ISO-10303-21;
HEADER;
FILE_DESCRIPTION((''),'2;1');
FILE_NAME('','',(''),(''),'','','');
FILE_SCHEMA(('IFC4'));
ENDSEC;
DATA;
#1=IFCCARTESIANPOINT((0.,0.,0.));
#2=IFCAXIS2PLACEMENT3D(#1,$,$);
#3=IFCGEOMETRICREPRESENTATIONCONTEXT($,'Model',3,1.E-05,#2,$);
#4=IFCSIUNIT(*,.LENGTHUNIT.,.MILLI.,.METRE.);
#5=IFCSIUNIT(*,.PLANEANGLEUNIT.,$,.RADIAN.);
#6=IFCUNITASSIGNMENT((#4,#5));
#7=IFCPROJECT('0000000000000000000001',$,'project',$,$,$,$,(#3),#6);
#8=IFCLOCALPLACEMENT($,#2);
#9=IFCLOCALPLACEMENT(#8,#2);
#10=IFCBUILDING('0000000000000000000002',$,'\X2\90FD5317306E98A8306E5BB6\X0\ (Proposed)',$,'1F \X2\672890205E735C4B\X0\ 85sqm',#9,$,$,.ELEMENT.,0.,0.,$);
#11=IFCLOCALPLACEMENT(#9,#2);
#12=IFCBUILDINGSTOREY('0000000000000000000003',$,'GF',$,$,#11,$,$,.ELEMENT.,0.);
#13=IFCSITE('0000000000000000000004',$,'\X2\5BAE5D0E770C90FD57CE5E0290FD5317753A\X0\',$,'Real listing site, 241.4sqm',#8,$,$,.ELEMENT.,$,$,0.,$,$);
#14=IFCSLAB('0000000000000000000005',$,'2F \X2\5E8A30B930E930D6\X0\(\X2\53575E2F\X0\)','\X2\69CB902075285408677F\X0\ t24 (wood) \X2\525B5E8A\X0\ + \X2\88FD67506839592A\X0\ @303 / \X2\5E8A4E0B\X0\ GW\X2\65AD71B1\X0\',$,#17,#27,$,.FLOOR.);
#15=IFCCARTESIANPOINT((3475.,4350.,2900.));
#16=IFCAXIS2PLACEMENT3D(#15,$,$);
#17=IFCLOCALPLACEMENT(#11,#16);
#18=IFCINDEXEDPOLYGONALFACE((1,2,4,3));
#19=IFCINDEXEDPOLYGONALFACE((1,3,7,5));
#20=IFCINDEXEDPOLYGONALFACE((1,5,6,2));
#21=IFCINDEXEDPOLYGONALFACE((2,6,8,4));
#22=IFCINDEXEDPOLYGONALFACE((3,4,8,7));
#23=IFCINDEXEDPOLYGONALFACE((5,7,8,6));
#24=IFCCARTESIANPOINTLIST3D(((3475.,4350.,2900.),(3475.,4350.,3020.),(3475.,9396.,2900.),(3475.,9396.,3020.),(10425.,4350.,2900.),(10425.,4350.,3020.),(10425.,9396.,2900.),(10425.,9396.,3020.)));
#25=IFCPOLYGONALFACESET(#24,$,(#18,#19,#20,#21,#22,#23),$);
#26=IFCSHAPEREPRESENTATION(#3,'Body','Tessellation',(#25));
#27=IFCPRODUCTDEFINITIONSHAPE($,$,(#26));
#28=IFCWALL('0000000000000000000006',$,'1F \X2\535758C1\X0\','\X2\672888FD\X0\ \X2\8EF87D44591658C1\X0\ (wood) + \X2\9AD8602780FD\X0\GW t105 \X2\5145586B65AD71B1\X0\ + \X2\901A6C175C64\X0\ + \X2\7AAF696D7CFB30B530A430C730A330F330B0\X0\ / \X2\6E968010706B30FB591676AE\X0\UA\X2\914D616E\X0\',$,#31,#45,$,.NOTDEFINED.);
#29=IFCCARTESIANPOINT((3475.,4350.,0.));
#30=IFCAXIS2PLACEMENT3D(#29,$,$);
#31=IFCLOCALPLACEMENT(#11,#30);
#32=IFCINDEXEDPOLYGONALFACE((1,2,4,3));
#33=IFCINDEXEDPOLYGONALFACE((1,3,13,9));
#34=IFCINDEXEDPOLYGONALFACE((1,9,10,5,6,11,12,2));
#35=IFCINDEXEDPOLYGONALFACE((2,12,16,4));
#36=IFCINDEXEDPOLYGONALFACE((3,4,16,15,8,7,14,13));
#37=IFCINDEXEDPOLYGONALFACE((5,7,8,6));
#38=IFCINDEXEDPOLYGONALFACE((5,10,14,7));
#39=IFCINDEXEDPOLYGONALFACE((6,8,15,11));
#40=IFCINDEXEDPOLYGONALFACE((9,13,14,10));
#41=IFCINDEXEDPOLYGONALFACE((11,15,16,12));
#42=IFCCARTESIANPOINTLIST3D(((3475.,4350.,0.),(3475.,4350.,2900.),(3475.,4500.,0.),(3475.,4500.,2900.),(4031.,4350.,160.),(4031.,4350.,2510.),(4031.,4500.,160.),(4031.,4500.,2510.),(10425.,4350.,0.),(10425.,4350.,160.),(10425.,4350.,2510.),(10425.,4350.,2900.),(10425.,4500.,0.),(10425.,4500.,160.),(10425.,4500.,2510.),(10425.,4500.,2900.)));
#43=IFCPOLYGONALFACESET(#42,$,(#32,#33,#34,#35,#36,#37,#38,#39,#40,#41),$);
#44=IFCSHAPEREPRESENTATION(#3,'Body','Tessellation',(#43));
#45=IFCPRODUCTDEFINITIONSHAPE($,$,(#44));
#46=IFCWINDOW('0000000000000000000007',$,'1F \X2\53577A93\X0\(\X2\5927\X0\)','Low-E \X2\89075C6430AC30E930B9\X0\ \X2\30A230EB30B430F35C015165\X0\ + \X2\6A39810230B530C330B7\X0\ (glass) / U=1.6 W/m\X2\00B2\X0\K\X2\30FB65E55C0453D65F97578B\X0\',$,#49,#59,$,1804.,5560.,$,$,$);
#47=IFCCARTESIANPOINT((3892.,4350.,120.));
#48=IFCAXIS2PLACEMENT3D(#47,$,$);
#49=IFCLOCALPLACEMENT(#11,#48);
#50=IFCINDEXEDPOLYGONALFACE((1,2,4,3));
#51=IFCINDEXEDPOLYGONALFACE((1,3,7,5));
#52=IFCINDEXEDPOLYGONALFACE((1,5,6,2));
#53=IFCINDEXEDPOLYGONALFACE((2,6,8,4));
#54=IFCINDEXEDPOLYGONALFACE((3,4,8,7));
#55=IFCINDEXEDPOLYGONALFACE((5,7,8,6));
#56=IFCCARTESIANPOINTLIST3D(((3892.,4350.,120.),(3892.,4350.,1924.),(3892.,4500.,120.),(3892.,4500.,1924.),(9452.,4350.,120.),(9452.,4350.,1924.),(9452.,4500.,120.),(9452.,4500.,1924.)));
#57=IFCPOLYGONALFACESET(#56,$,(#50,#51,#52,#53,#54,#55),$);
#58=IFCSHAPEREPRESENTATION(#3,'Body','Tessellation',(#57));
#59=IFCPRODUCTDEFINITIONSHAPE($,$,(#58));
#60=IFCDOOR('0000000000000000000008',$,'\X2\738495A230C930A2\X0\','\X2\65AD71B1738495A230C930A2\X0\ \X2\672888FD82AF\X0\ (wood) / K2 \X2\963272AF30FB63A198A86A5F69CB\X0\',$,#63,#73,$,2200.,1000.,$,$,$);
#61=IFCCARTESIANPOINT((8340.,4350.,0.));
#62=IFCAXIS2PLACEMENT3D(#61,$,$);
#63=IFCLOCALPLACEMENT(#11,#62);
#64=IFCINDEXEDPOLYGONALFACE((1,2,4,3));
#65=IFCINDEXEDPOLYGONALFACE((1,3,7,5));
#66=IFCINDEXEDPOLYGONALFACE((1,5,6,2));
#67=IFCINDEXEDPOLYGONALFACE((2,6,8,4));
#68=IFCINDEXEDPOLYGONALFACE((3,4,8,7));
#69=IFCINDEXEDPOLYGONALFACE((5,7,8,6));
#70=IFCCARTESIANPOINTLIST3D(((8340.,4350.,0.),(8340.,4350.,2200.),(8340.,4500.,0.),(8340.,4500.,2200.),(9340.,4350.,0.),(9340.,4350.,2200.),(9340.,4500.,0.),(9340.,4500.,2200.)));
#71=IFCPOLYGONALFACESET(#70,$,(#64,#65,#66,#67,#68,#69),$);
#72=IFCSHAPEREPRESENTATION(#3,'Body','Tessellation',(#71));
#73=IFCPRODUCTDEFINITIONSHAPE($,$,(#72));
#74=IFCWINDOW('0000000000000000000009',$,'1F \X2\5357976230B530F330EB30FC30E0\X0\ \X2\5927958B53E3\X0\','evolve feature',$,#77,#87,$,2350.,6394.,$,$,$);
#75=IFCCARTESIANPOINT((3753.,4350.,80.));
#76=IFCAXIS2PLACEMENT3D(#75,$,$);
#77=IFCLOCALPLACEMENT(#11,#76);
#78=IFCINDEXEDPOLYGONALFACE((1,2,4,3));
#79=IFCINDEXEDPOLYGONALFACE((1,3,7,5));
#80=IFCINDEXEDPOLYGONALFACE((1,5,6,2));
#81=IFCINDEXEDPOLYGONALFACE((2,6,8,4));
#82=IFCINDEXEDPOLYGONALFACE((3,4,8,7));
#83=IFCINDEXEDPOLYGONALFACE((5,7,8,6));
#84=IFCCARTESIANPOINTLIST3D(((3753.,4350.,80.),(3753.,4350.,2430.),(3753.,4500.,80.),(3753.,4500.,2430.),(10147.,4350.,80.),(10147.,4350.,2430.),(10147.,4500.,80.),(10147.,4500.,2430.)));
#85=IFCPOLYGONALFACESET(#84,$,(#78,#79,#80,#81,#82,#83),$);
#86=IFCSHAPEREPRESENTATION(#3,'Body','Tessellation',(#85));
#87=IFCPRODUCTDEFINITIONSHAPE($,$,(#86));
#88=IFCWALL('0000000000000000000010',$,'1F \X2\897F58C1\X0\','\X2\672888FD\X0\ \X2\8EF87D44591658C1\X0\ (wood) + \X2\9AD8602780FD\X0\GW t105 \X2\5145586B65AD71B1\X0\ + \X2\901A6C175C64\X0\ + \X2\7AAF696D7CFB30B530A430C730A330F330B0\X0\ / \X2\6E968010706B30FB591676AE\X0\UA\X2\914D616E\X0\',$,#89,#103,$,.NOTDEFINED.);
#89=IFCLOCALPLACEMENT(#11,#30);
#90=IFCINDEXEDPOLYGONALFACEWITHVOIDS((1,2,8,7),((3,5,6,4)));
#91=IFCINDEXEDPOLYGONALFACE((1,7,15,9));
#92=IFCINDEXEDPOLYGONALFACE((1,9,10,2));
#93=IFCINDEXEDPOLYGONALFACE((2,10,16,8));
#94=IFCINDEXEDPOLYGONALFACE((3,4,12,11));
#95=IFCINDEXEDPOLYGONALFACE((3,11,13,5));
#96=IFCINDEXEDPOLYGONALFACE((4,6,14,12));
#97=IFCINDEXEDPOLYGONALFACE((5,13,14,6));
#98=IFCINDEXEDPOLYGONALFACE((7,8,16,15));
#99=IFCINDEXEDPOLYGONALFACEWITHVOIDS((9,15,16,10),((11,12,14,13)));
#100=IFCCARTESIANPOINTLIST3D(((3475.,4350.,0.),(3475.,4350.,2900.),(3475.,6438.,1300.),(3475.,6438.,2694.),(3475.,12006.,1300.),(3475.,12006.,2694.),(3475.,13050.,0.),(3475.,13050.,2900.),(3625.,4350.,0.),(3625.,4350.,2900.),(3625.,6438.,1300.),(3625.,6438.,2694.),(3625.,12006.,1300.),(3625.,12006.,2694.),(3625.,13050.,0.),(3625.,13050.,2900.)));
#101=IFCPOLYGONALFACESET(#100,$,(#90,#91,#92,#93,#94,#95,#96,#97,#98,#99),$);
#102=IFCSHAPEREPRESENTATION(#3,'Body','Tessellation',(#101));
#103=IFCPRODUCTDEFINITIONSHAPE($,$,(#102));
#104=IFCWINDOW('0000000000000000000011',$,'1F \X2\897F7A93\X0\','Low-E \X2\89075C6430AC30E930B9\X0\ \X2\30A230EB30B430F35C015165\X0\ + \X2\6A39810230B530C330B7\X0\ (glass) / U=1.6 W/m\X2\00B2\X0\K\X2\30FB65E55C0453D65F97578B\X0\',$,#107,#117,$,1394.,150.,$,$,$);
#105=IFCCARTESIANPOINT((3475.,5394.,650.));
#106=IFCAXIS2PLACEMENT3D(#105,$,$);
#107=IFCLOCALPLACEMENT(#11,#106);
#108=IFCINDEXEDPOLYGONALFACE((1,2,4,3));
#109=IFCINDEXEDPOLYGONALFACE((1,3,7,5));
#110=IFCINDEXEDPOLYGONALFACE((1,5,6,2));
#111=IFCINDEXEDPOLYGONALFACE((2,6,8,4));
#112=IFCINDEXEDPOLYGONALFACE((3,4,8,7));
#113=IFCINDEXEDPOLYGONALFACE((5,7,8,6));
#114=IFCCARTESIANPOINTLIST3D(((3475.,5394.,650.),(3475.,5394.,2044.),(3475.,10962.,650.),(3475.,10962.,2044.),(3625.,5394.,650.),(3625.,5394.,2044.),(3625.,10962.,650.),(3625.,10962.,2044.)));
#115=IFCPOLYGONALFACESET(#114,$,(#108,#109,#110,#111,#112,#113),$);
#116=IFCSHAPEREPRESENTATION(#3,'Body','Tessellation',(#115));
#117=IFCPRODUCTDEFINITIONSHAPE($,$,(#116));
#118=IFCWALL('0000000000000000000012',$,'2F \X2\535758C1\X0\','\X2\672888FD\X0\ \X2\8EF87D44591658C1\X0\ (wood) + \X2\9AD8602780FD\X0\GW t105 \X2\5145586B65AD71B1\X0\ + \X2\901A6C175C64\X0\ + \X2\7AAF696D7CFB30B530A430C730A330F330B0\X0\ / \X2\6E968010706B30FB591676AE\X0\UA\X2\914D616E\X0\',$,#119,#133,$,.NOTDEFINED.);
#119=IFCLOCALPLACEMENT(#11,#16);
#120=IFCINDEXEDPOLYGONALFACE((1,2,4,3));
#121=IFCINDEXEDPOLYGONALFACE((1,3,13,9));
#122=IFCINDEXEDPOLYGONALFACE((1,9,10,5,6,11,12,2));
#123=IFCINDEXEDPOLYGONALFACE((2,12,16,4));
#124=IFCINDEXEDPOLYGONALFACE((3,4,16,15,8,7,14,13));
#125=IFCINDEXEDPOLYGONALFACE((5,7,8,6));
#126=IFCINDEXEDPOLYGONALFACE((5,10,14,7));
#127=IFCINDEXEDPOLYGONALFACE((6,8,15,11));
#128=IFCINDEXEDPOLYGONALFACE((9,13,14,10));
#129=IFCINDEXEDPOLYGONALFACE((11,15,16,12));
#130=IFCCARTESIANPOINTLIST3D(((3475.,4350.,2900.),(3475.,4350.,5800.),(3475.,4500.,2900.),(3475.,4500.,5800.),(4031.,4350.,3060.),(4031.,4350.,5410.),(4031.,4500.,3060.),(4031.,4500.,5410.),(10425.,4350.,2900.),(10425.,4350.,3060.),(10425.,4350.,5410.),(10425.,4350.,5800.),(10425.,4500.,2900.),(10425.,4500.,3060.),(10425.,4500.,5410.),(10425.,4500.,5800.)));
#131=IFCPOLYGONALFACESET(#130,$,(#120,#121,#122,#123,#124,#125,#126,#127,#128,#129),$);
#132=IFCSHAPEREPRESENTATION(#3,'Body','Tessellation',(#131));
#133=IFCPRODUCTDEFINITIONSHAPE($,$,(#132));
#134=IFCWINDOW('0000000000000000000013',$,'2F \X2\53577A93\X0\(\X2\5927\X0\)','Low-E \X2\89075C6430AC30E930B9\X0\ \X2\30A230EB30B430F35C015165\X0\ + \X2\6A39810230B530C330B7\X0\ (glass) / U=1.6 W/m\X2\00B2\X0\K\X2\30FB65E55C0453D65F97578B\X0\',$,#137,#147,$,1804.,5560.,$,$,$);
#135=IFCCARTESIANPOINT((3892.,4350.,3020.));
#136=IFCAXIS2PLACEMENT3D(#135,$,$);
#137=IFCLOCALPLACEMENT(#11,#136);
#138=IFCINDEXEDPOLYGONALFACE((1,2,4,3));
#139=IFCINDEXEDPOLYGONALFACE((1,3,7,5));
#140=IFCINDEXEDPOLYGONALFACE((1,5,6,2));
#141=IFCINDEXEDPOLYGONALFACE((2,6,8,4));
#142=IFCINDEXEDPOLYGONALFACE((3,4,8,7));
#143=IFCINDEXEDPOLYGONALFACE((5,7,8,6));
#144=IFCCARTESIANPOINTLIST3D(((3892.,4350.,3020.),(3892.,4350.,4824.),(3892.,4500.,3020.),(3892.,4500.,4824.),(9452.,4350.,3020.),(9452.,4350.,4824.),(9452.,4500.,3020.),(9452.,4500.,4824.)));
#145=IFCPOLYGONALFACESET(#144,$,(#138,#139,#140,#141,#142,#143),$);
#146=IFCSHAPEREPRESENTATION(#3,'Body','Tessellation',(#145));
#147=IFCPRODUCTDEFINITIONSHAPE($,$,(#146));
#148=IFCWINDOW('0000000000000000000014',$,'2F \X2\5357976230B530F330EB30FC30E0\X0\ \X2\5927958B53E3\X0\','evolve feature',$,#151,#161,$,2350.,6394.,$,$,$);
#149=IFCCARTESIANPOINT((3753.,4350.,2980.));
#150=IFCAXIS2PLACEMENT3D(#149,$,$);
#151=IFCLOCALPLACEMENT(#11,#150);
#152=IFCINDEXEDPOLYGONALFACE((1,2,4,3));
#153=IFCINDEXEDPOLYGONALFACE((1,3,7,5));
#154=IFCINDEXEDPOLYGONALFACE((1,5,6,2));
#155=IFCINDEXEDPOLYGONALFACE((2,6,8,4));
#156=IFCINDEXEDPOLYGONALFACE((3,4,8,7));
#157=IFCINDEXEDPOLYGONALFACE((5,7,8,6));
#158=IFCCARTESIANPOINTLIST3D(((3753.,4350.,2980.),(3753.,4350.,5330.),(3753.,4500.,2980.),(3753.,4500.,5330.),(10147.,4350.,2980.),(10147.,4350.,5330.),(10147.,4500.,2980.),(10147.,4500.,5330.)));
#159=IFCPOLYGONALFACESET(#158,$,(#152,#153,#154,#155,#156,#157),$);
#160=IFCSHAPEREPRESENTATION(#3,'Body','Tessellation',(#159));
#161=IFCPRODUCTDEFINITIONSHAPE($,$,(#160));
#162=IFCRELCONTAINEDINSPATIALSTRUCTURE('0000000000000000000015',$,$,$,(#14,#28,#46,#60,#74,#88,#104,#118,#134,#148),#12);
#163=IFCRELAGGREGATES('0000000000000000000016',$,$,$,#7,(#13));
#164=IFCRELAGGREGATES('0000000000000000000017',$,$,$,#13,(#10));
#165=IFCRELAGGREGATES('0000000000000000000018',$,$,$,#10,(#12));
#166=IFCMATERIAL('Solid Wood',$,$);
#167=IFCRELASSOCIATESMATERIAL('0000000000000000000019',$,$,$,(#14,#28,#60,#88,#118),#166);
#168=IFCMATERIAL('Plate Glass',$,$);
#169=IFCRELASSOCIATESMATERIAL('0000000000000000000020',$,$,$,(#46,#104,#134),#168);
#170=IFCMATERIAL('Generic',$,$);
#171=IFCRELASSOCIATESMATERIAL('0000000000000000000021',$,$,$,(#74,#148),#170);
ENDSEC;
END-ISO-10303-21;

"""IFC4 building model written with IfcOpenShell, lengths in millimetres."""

from ifc_helpers import new_model, si_unit, frame, frame_2d, origin, place, context, project, spatial, rectangle, extrude, material, element, fill, save


model = new_model("IFC4")

# Units and contexts
model_context = context("Model", 3, precision=1e-05, world=origin())
ifc_project = project(units=[si_unit("LENGTHUNIT", "METRE", prefix="MILLI"), si_unit("PLANEANGLEUNIT", "RADIAN")], contexts=[model_context])

# Site, building, storey
site_placement = place(None, origin())
site = spatial("IfcSite", under=ifc_project, at=site_placement, Name="宮崎県都城市都北町", ObjectType="Real listing site, 241.4sqm", CompositionType="ELEMENT", RefElevation=0.0)
building_placement = place(site_placement, origin())
building = spatial("IfcBuilding", under=site, at=building_placement, Name="都北の風の家 (Proposed)", ObjectType="1F 木造平屋 85sqm", CompositionType="ELEMENT", ElevationOfRefHeight=0.0, ElevationOfTerrain=0.0)
storey_placement = place(building_placement, origin())
storey = spatial("IfcBuildingStorey", under=building, at=storey_placement, Name="GF", CompositionType="ELEMENT", Elevation=0.0)

# Slab
ifc_material_1 = material(Name="Solid Wood")
slab_1_placement = place(storey_placement, frame((3475.0, 4350.0, 2900.0)))
element("IfcSlab", 1, at=slab_1_placement, inside=storey, material=ifc_material_1, Name="2F 床スラブ(南帯)", Description="構造用合板 t24 (wood) 剛床 + 製材根太 @303 / 床下 GW断熱", PredefinedType="FLOOR", context=model_context, shape_type="SweptSolid", body=[
    extrude(rectangle(XDim=6950.0, YDim=5046.0, at=frame_2d((3475.0, 2523.0))), frame((3475.0, 4350.0, 2900.0)), (0.0, 0.0, 1.0), 120.0),
])
ifc_material_2 = material(Name="Generic")

# Wall, openings, windows, door
wall_1_placement = place(storey_placement, frame((3475.0, 4350.0, 0.0)))
wall_1 = element("IfcWall", 2, at=wall_1_placement, inside=storey, material=ifc_material_1, Name="1F 南壁", Description="木製 軸組外壁 (wood) + 高性能GW t105 充填断熱 + 通気層 + 窯業系サイディング / 準耐火・外皮UA配慮", PredefinedType="NOTDEFINED", context=model_context, shape_type="SweptSolid", body=[
    extrude(rectangle(XDim=6950.0, YDim=150.0, at=frame_2d((3475.0, 75.0))), frame((3475.0, 4350.0, 0.0)), (0.0, 0.0, 1.0), 2900.0),
])
opening_1_placement = place(storey_placement, frame((3892.0, 4350.0, 120.0)))
opening_1 = element("IfcOpeningElement", 3, at=opening_1_placement, cuts=wall_1, PredefinedType="NOTDEFINED", context=model_context, shape_type="SweptSolid", body=[
    extrude(rectangle(XDim=5560.0, YDim=150.0, at=frame_2d((2780.0, 75.0))), frame((3892.0, 4350.0, 120.0)), (0.0, 0.0, 1.0), 1804.0),
])
opening_2_placement = place(storey_placement, frame((8340.0, 4350.0, 0.0)))
opening_2 = element("IfcOpeningElement", 4, at=opening_2_placement, cuts=wall_1, PredefinedType="NOTDEFINED", context=model_context, shape_type="SweptSolid", body=[
    extrude(rectangle(XDim=1000.0, YDim=150.0, at=frame_2d((500.0, 75.0))), frame((8340.0, 4350.0, 0.0)), (0.0, 0.0, 1.0), 2200.0),
])
opening_3_placement = place(storey_placement, frame((3753.0, 4350.0, 80.0)))
opening_3 = element("IfcOpeningElement", 5, at=opening_3_placement, cuts=wall_1, PredefinedType="NOTDEFINED", context=model_context, shape_type="SweptSolid", body=[
    extrude(rectangle(XDim=6394.0, YDim=150.0, at=frame_2d((3197.0, 75.0))), frame((3753.0, 4350.0, 80.0)), (0.0, 0.0, 1.0), 2350.0),
])
ifc_material_3 = material(Name="Plate Glass")
window_1_placement = place(storey_placement, frame((3892.0, 4350.0, 120.0)))
window_1 = element("IfcWindow", 6, at=window_1_placement, inside=storey, material=ifc_material_3, Name="1F 南窓(大)", Description="Low-E 複層ガラス アルゴン封入 + 樹脂サッシ (glass) / U=1.6 W/m²K・日射取得型", OverallHeight=1804.0, OverallWidth=5560.0, context=model_context, shape_type="SweptSolid", body=[
    extrude(rectangle(XDim=5560.0, YDim=150.0, at=frame_2d((2780.0, 75.0))), frame((3892.0, 4350.0, 120.0)), (0.0, 0.0, 1.0), 1804.0),
])
fill(opening_1, window_1)
door_placement = place(storey_placement, frame((8340.0, 4350.0, 0.0)))
door = element("IfcDoor", 7, at=door_placement, inside=storey, material=ifc_material_1, Name="玄関ドア", Description="断熱玄関ドア 木製芯 (wood) / K2 防犯・採風機構", OverallHeight=2200.0, OverallWidth=1000.0, context=model_context, shape_type="SweptSolid", body=[
    extrude(rectangle(XDim=1000.0, YDim=150.0, at=frame_2d((500.0, 75.0))), frame((8340.0, 4350.0, 0.0)), (0.0, 0.0, 1.0), 2200.0),
])
fill(opening_2, door)
window_2_placement = place(storey_placement, frame((3753.0, 4350.0, 80.0)))
window_2 = element("IfcWindow", 8, at=window_2_placement, inside=storey, material=ifc_material_2, Name="1F 南面サンルーム 大開口", Description="evolve feature", OverallHeight=2350.0, OverallWidth=6394.0, context=model_context, shape_type="SweptSolid", body=[
    extrude(rectangle(XDim=6394.0, YDim=150.0, at=frame_2d((3197.0, 75.0))), frame((3753.0, 4350.0, 80.0)), (0.0, 0.0, 1.0), 2350.0),
])
fill(opening_3, window_2)

# Wall, opening, window
wall_2_placement = place(storey_placement, frame((3475.0, 4350.0, 0.0)))
wall_2 = element("IfcWall", 9, at=wall_2_placement, inside=storey, material=ifc_material_1, Name="1F 西壁", Description="木製 軸組外壁 (wood) + 高性能GW t105 充填断熱 + 通気層 + 窯業系サイディング / 準耐火・外皮UA配慮", PredefinedType="NOTDEFINED", context=model_context, shape_type="SweptSolid", body=[
    extrude(rectangle(XDim=150.0, YDim=8700.0, at=frame_2d((75.0, 4350.0))), frame((3475.0, 4350.0, 0.0)), (0.0, 0.0, 1.0), 2900.0),
])
opening_4_placement = place(storey_placement, frame((3475.0, 5394.0, 650.0)))
opening_4 = element("IfcOpeningElement", 10, at=opening_4_placement, cuts=wall_2, PredefinedType="NOTDEFINED", context=model_context, shape_type="SweptSolid", body=[
    extrude(rectangle(XDim=150.0, YDim=5568.0, at=frame_2d((75.0, 2784.0))), frame((3475.0, 5394.0, 650.0)), (0.0, 0.0, 1.0), 1394.0),
])
window_3_placement = place(storey_placement, frame((3475.0, 5394.0, 650.0)))
window_3 = element("IfcWindow", 11, at=window_3_placement, inside=storey, material=ifc_material_3, Name="1F 西窓", Description="Low-E 複層ガラス アルゴン封入 + 樹脂サッシ (glass) / U=1.6 W/m²K・日射取得型", OverallHeight=1394.0, OverallWidth=150.0, context=model_context, shape_type="SweptSolid", body=[
    extrude(rectangle(XDim=150.0, YDim=5568.0, at=frame_2d((75.0, 2784.0))), frame((3475.0, 5394.0, 650.0)), (0.0, 0.0, 1.0), 1394.0),
])
fill(opening_4, window_3)

# Wall, openings, windows
wall_3_placement = place(storey_placement, frame((3475.0, 4350.0, 2900.0)))
wall_3 = element("IfcWall", 12, at=wall_3_placement, inside=storey, material=ifc_material_1, Name="2F 南壁", Description="木製 軸組外壁 (wood) + 高性能GW t105 充填断熱 + 通気層 + 窯業系サイディング / 準耐火・外皮UA配慮", PredefinedType="NOTDEFINED", context=model_context, shape_type="SweptSolid", body=[
    extrude(rectangle(XDim=6950.0, YDim=150.0, at=frame_2d((3475.0, 75.0))), frame((3475.0, 4350.0, 2900.0)), (0.0, 0.0, 1.0), 2900.0),
])
opening_5_placement = place(storey_placement, frame((3892.0, 4350.0, 3020.0)))
opening_5 = element("IfcOpeningElement", 13, at=opening_5_placement, cuts=wall_3, PredefinedType="NOTDEFINED", context=model_context, shape_type="SweptSolid", body=[
    extrude(rectangle(XDim=5560.0, YDim=150.0, at=frame_2d((2780.0, 75.0))), frame((3892.0, 4350.0, 3020.0)), (0.0, 0.0, 1.0), 1804.0),
])
opening_6_placement = place(storey_placement, frame((3753.0, 4350.0, 2980.0)))
opening_6 = element("IfcOpeningElement", 14, at=opening_6_placement, cuts=wall_3, PredefinedType="NOTDEFINED", context=model_context, shape_type="SweptSolid", body=[
    extrude(rectangle(XDim=6394.0, YDim=150.0, at=frame_2d((3197.0, 75.0))), frame((3753.0, 4350.0, 2980.0)), (0.0, 0.0, 1.0), 2350.0),
])
window_4_placement = place(storey_placement, frame((3892.0, 4350.0, 3020.0)))
window_4 = element("IfcWindow", 15, at=window_4_placement, inside=storey, material=ifc_material_3, Name="2F 南窓(大)", Description="Low-E 複層ガラス アルゴン封入 + 樹脂サッシ (glass) / U=1.6 W/m²K・日射取得型", OverallHeight=1804.0, OverallWidth=5560.0, context=model_context, shape_type="SweptSolid", body=[
    extrude(rectangle(XDim=5560.0, YDim=150.0, at=frame_2d((2780.0, 75.0))), frame((3892.0, 4350.0, 3020.0)), (0.0, 0.0, 1.0), 1804.0),
])
fill(opening_5, window_4)
window_5_placement = place(storey_placement, frame((3753.0, 4350.0, 2980.0)))
window_5 = element("IfcWindow", 16, at=window_5_placement, inside=storey, material=ifc_material_2, Name="2F 南面サンルーム 大開口", Description="evolve feature", OverallHeight=2350.0, OverallWidth=6394.0, context=model_context, shape_type="SweptSolid", body=[
    extrude(rectangle(XDim=6394.0, YDim=150.0, at=frame_2d((3197.0, 75.0))), frame((3753.0, 4350.0, 2980.0)), (0.0, 0.0, 1.0), 2350.0),
])
fill(opening_6, window_5)

save(model, "model.ifc")
